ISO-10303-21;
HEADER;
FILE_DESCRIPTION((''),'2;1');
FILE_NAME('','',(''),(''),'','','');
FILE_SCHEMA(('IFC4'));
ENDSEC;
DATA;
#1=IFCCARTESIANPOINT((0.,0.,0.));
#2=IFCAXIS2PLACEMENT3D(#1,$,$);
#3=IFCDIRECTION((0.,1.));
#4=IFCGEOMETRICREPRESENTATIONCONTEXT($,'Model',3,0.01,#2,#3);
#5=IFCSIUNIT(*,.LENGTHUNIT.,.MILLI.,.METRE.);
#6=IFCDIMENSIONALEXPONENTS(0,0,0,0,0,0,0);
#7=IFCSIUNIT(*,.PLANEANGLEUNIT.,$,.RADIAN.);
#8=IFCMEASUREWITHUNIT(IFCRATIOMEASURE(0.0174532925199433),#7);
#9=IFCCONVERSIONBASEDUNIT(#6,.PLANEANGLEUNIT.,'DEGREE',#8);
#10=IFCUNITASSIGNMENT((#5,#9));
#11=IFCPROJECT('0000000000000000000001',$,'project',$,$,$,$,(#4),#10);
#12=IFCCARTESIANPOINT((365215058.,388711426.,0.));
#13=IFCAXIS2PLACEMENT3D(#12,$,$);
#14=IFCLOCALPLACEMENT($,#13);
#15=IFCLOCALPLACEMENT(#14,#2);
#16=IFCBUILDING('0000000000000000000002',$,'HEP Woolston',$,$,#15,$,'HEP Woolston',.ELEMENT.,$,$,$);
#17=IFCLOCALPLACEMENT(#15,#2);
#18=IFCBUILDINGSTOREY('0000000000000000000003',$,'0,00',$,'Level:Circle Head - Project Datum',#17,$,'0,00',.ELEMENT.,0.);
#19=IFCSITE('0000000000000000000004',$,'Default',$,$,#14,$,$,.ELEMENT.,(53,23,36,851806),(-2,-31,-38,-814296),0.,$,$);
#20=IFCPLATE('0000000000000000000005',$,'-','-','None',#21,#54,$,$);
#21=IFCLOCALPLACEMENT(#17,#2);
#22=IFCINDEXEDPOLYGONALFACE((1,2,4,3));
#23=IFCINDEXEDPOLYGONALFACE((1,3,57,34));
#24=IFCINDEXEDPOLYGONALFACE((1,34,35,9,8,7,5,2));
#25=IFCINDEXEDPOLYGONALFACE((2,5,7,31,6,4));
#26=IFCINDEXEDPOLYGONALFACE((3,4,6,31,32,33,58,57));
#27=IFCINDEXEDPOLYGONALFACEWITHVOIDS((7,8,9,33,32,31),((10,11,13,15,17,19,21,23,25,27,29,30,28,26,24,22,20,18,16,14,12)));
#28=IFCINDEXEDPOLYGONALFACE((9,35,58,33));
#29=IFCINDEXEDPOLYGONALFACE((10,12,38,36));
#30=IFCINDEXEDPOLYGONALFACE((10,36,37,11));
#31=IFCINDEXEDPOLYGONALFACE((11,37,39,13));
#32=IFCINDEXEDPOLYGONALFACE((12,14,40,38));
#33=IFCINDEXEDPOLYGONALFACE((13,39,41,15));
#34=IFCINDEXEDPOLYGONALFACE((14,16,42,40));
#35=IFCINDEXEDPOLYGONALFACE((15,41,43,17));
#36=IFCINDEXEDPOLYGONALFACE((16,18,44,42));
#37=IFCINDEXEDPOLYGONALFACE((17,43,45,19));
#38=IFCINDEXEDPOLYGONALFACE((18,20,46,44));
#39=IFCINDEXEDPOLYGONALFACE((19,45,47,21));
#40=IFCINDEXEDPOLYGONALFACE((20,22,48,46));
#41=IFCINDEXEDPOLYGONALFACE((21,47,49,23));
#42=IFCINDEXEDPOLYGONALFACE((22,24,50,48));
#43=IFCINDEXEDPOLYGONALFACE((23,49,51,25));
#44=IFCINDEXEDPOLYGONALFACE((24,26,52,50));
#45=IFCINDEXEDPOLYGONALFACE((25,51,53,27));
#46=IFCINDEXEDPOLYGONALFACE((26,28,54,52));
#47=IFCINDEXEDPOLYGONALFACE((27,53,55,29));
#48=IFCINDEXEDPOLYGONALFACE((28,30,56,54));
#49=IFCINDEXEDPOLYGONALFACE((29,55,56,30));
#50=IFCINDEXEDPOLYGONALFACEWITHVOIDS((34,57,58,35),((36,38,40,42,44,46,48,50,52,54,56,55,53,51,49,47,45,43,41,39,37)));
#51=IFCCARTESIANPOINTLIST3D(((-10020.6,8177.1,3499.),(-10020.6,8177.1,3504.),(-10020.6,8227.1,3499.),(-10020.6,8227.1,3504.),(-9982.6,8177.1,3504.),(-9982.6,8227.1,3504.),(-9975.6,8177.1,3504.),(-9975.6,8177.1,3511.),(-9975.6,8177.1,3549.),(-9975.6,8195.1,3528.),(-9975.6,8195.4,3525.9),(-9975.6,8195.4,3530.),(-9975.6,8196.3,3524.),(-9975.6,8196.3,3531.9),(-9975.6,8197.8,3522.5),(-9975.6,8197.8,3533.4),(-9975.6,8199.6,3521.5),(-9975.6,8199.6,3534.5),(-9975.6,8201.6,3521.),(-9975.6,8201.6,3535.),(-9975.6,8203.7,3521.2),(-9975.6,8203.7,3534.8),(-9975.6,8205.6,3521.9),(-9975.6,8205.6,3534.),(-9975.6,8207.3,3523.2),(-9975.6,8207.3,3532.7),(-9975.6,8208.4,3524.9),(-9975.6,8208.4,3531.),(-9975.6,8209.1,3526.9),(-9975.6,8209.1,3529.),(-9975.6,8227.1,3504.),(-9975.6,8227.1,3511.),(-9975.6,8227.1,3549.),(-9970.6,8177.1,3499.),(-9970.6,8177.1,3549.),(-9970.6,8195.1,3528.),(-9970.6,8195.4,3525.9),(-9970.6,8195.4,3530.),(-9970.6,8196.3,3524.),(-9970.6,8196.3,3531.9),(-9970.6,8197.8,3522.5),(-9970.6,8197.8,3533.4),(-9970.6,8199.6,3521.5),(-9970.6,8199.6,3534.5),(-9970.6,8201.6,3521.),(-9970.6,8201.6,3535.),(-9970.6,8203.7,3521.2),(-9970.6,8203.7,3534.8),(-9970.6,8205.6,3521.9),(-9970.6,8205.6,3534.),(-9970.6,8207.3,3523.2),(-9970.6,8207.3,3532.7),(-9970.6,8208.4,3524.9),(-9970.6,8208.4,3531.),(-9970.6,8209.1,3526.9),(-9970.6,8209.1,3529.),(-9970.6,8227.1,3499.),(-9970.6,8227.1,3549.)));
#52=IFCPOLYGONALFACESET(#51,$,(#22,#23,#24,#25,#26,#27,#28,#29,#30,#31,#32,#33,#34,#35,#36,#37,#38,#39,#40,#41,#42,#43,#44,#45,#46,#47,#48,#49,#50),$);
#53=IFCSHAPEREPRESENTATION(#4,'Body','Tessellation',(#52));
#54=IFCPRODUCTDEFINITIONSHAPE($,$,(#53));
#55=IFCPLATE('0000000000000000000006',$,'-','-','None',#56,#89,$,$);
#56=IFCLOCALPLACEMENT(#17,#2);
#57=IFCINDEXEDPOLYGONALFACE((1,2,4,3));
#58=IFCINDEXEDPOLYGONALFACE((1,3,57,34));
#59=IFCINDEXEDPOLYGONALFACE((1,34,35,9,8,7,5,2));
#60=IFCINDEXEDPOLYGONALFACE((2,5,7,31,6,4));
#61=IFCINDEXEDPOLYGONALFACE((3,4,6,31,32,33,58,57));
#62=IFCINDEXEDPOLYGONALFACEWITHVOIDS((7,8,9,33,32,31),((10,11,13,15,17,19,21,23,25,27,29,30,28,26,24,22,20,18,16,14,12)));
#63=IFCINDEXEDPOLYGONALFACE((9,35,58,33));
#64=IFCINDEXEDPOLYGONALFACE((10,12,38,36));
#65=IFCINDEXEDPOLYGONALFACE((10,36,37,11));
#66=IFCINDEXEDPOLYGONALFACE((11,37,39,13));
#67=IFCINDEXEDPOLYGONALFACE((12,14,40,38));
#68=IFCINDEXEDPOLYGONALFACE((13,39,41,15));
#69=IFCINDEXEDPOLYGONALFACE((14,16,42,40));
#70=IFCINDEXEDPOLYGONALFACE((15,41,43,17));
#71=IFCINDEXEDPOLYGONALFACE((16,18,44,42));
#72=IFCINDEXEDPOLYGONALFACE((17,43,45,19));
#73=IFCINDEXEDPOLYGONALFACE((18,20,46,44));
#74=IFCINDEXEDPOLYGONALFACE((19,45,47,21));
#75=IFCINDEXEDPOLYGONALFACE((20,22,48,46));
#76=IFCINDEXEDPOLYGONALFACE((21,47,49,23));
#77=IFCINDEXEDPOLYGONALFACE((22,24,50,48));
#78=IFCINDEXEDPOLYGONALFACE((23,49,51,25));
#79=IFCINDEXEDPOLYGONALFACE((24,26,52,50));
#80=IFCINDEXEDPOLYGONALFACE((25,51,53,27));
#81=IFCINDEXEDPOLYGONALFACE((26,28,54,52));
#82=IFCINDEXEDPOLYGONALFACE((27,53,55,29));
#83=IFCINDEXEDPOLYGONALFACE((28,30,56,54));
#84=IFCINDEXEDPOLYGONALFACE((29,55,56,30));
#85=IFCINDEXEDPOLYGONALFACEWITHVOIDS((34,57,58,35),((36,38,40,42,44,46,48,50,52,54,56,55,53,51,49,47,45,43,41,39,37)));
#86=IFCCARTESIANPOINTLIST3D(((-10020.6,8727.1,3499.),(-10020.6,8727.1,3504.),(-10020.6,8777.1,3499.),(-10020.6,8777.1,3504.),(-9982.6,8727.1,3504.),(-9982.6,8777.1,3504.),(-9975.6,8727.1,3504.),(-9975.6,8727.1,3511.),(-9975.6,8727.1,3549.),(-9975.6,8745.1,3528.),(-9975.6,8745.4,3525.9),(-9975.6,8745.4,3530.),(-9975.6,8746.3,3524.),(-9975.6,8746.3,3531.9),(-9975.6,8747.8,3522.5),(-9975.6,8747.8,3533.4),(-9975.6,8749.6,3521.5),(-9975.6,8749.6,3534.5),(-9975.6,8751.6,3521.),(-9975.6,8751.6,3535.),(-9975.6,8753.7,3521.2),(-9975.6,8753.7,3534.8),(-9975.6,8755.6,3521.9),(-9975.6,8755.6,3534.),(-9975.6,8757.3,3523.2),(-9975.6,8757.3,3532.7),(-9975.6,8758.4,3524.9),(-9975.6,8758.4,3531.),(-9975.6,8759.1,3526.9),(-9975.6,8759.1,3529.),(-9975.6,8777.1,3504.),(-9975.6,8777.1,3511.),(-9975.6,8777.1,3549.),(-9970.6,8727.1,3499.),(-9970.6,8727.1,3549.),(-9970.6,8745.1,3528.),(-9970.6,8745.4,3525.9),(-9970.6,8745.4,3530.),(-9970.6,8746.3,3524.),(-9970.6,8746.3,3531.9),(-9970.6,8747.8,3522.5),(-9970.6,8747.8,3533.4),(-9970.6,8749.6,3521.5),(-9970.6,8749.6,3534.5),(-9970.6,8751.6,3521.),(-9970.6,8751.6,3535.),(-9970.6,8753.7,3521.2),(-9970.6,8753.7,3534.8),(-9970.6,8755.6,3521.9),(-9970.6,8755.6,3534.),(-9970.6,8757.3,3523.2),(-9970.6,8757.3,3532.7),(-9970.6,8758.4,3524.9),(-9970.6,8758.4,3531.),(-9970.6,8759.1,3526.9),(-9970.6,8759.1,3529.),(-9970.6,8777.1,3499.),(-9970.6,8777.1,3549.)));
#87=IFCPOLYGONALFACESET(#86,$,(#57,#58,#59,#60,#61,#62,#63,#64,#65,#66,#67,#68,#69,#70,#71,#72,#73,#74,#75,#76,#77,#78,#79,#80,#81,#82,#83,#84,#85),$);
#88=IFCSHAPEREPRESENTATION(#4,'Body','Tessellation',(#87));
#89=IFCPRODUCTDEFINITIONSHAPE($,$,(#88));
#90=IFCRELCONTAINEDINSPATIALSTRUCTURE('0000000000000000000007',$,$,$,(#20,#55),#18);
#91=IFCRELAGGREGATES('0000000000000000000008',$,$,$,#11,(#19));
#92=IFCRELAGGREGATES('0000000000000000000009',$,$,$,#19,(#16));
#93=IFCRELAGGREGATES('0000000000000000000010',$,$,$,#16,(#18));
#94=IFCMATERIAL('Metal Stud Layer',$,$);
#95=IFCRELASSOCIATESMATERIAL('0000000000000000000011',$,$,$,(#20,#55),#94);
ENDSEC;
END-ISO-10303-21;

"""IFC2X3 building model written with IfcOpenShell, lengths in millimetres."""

from ifc_helpers import new_model, entity, si_unit, converted_unit, point, direction, frame, frame_2d, origin, origin_with_axes, origin_2d_with_axis, place, context, project, spatial, polyline, circle_curve, line_curve, trimmed, segment, composite_curve, circle, outline, extrude, material, element, save


model = new_model("IFC2X3")

# Units and contexts
model_context = context("Model", 3, precision=0.01, world=origin(), true_north=direction((0.0, 1.0)))
ifc_project = project(units=[si_unit("LENGTHUNIT", "METRE", prefix="MILLI"), converted_unit("PLANEANGLEUNIT", "DEGREE", entity("IfcRatioMeasure", 0.0174532925199433), si_unit("PLANEANGLEUNIT", "RADIAN"), dimensions=[0, 0, 0, 0, 0, 0, 0])], contexts=[model_context])

# Site, building, storey
site_placement = place(None, frame((365215058.0, 388711426.0, 0.0)))
site = spatial("IfcSite", under=ifc_project, at=site_placement, Name="Default", CompositionType="ELEMENT", RefLatitude=(53, 23, 36, 851806), RefLongitude=(-2, -31, -38, -814296), RefElevation=0.0)
building_placement = place(site_placement, origin())
building = spatial("IfcBuilding", under=site, at=building_placement, Name="HEP Woolston", LongName="HEP Woolston", CompositionType="ELEMENT")
storey_placement = place(building_placement, origin())
storey = spatial("IfcBuildingStorey", under=building, at=storey_placement, Name="0,00", ObjectType="Level:Circle Head - Project Datum", LongName="0,00", CompositionType="ELEMENT", Elevation=0.0)

# Plates, openings
ifc_material = material(Name="Metal Stud Layer")
plate_1_placement = place(storey_placement, frame((-9970.6, 8177.1, 3499.0), z_axis=(0.0, 1.0, 0.0), x_axis=(-1.0, 0.0, 0.0)))
plate_1 = element("IfcPlate", 1, at=plate_1_placement, inside=storey, material=ifc_material, Name="-", Description="-", ObjectType="None", context=model_context, shape_type="SweptSolid", body=[
    extrude(outline(polyline([(0.0, 0.0), (50.0, 0.0), (50.0, 5.0), (5.0, 5.0), (5.0, 50.0), (0.0, 50.0), (0.0, 0.0)])), origin_with_axes(), (0.0, 0.0, 1.0), 50.0),
])
opening_1_placement = place(plate_1_placement, frame((0.0, 0.0, 0.0), z_axis=(0.0, 0.0, 1.0), x_axis=(1.0, 0.0, 0.0)))
element("IfcOpeningElement", 2, at=opening_1_placement, cuts=plate_1, ObjectType="Opening", context=model_context, shape_type="SweptSolid", body=[
    extrude(outline(composite_curve([segment(trimmed(line_curve((50.0, 5.0), (1.0, 0.0), 3.532613), [point((50.0, 5.0))], [point((46.5, 5.0))], True, "CARTESIAN"), True, "CONTINUOUS"), segment(trimmed(circle_curve(frame_2d((46.5, 1.5), x_axis=(-1.0, 0.0)), 3.5), [point((46.5, 5.0))], [point((50.0, 1.5))], False, "CARTESIAN"), True, "CONTINUOUS"), segment(trimmed(line_curve((50.0, 1.5), (0.0, -1.0), 3.532613), [point((50.0, 1.5))], [point((50.0, 5.0))], True, "CARTESIAN"), True, "CONTINUOUS")], self_intersect="UNKNOWN")), origin(), (0.0, 0.0, 1.0), 50.0),
])
opening_2_placement = place(plate_1_placement, origin_with_axes())
element("IfcOpeningElement", 3, at=opening_2_placement, cuts=plate_1, ObjectType="Opening", context=model_context, shape_type="SweptSolid", body=[
    extrude(outline(composite_curve([segment(trimmed(line_curve((5.0, 5.0), (0.0, -1.0), 7.046301), [point((5.0, 5.0))], [point((5.0, 12.0))], False, "CARTESIAN"), True, "CONTINUOUS"), segment(trimmed(circle_curve(frame_2d((12.0, 12.0), x_axis=(1.0, 0.0)), 7.0), [point((5.0, 12.0))], [point((12.0, 5.0))], True, "CARTESIAN"), True, "CONTINUOUS"), segment(trimmed(line_curve((12.0, 5.0), (1.0, 0.0), 7.046301), [point((12.0, 5.0))], [point((5.0, 5.0))], False, "CARTESIAN"), True, "CONTINUOUS")], self_intersect="UNKNOWN")), origin(), (0.0, 0.0, 1.0), 50.0),
])
opening_3_placement = place(plate_1_placement, frame((0.0, 0.0, 0.0), z_axis=(0.0, 0.0, 1.0), x_axis=(1.0, 0.0, 0.0)))
element("IfcOpeningElement", 4, at=opening_3_placement, cuts=plate_1, ObjectType="Opening", context=model_context, shape_type="SweptSolid", body=[
    extrude(outline(composite_curve([segment(trimmed(line_curve((5.0, 50.0), (1.0, 0.0), 3.4874), [point((5.0, 50.0))], [point((1.5, 50.0))], True, "CARTESIAN"), True, "CONTINUOUS"), segment(trimmed(circle_curve(frame_2d((1.5, 46.5), x_axis=(-1.0, 0.0)), 3.5), [point((1.5, 50.0))], [point((5.0, 46.5))], False, "CARTESIAN"), True, "CONTINUOUS"), segment(trimmed(line_curve((5.0, 46.5), (0.0, -1.0), 3.4874), [point((5.0, 46.5))], [point((5.0, 50.0))], True, "CARTESIAN"), True, "CONTINUOUS")], self_intersect="UNKNOWN")), origin(), (0.0, 0.0, 1.0), 50.0),
])
opening_4_placement = place(plate_1_placement, frame((-0.5, 29.0, 25.0), z_axis=(1.0, 0.0, 0.0), x_axis=(0.0, 0.0, -1.0)))
element("IfcOpeningElement", 5, at=opening_4_placement, cuts=plate_1, ObjectType="Opening", context=model_context, shape_type="SweptSolid", body=[
    extrude(circle(Radius=7.0, at=origin_2d_with_axis()), origin(), (0.0, 0.0, 1.0), 6.0),
])
plate_2_placement = place(storey_placement, frame((-9970.6, 8727.1, 3499.0), z_axis=(0.0, 1.0, 0.0), x_axis=(-1.0, 0.0, 0.0)))
plate_2 = element("IfcPlate", 6, at=plate_2_placement, inside=storey, material=ifc_material, Name="-", Description="-", ObjectType="None", context=model_context, shape_type="SweptSolid", body=[
    extrude(outline(polyline([(0.0, 0.0), (50.0, 0.0), (50.0, 5.0), (5.0, 5.0), (5.0, 50.0), (0.0, 50.0), (0.0, 0.0)])), origin_with_axes(), (0.0, 0.0, 1.0), 50.0),
])
opening_5_placement = place(plate_2_placement, frame((0.0, 0.0, 0.0), z_axis=(0.0, 0.0, 1.0), x_axis=(1.0, 0.0, 0.0)))
element("IfcOpeningElement", 7, at=opening_5_placement, cuts=plate_2, ObjectType="Opening", context=model_context, shape_type="SweptSolid", body=[
    extrude(outline(composite_curve([segment(trimmed(line_curve((50.0, 5.0), (1.0, 0.0), 3.532613), [point((50.0, 5.0))], [point((46.5, 5.0))], True, "CARTESIAN"), True, "CONTINUOUS"), segment(trimmed(circle_curve(frame_2d((46.5, 1.5), x_axis=(-1.0, 0.0)), 3.5), [point((46.5, 5.0))], [point((50.0, 1.5))], False, "CARTESIAN"), True, "CONTINUOUS"), segment(trimmed(line_curve((50.0, 1.5), (0.0, -1.0), 3.532613), [point((50.0, 1.5))], [point((50.0, 5.0))], True, "CARTESIAN"), True, "CONTINUOUS")], self_intersect="UNKNOWN")), origin(), (0.0, 0.0, 1.0), 50.0),
])
opening_6_placement = place(plate_2_placement, origin_with_axes())
element("IfcOpeningElement", 8, at=opening_6_placement, cuts=plate_2, ObjectType="Opening", context=model_context, shape_type="SweptSolid", body=[
    extrude(outline(composite_curve([segment(trimmed(line_curve((5.0, 5.0), (0.0, -1.0), 7.046301), [point((5.0, 5.0))], [point((5.0, 12.0))], False, "CARTESIAN"), True, "CONTINUOUS"), segment(trimmed(circle_curve(frame_2d((12.0, 12.0), x_axis=(1.0, 0.0)), 7.0), [point((5.0, 12.0))], [point((12.0, 5.0))], True, "CARTESIAN"), True, "CONTINUOUS"), segment(trimmed(line_curve((12.0, 5.0), (1.0, 0.0), 7.046301), [point((12.0, 5.0))], [point((5.0, 5.0))], False, "CARTESIAN"), True, "CONTINUOUS")], self_intersect="UNKNOWN")), origin(), (0.0, 0.0, 1.0), 50.0),
])
opening_7_placement = place(plate_2_placement, frame((0.0, 0.0, 0.0), z_axis=(0.0, 0.0, 1.0), x_axis=(1.0, 0.0, 0.0)))
element("IfcOpeningElement", 9, at=opening_7_placement, cuts=plate_2, ObjectType="Opening", context=model_context, shape_type="SweptSolid", body=[
    extrude(outline(composite_curve([segment(trimmed(line_curve((5.0, 50.0), (1.0, 0.0), 3.4874), [point((5.0, 50.0))], [point((1.5, 50.0))], True, "CARTESIAN"), True, "CONTINUOUS"), segment(trimmed(circle_curve(frame_2d((1.5, 46.5), x_axis=(-1.0, 0.0)), 3.5), [point((1.5, 50.0))], [point((5.0, 46.5))], False, "CARTESIAN"), True, "CONTINUOUS"), segment(trimmed(line_curve((5.0, 46.5), (0.0, -1.0), 3.4874), [point((5.0, 46.5))], [point((5.0, 50.0))], True, "CARTESIAN"), True, "CONTINUOUS")], self_intersect="UNKNOWN")), origin(), (0.0, 0.0, 1.0), 50.0),
])
opening_8_placement = place(plate_2_placement, frame((-0.5, 29.0, 25.0), z_axis=(1.0, 0.0, 0.0), x_axis=(0.0, 0.0, -1.0)))
element("IfcOpeningElement", 10, at=opening_8_placement, cuts=plate_2, ObjectType="Opening", context=model_context, shape_type="SweptSolid", body=[
    extrude(circle(Radius=7.0, at=origin_2d_with_axis()), origin(), (0.0, 0.0, 1.0), 6.0),
])

save(model, "model.ifc")
